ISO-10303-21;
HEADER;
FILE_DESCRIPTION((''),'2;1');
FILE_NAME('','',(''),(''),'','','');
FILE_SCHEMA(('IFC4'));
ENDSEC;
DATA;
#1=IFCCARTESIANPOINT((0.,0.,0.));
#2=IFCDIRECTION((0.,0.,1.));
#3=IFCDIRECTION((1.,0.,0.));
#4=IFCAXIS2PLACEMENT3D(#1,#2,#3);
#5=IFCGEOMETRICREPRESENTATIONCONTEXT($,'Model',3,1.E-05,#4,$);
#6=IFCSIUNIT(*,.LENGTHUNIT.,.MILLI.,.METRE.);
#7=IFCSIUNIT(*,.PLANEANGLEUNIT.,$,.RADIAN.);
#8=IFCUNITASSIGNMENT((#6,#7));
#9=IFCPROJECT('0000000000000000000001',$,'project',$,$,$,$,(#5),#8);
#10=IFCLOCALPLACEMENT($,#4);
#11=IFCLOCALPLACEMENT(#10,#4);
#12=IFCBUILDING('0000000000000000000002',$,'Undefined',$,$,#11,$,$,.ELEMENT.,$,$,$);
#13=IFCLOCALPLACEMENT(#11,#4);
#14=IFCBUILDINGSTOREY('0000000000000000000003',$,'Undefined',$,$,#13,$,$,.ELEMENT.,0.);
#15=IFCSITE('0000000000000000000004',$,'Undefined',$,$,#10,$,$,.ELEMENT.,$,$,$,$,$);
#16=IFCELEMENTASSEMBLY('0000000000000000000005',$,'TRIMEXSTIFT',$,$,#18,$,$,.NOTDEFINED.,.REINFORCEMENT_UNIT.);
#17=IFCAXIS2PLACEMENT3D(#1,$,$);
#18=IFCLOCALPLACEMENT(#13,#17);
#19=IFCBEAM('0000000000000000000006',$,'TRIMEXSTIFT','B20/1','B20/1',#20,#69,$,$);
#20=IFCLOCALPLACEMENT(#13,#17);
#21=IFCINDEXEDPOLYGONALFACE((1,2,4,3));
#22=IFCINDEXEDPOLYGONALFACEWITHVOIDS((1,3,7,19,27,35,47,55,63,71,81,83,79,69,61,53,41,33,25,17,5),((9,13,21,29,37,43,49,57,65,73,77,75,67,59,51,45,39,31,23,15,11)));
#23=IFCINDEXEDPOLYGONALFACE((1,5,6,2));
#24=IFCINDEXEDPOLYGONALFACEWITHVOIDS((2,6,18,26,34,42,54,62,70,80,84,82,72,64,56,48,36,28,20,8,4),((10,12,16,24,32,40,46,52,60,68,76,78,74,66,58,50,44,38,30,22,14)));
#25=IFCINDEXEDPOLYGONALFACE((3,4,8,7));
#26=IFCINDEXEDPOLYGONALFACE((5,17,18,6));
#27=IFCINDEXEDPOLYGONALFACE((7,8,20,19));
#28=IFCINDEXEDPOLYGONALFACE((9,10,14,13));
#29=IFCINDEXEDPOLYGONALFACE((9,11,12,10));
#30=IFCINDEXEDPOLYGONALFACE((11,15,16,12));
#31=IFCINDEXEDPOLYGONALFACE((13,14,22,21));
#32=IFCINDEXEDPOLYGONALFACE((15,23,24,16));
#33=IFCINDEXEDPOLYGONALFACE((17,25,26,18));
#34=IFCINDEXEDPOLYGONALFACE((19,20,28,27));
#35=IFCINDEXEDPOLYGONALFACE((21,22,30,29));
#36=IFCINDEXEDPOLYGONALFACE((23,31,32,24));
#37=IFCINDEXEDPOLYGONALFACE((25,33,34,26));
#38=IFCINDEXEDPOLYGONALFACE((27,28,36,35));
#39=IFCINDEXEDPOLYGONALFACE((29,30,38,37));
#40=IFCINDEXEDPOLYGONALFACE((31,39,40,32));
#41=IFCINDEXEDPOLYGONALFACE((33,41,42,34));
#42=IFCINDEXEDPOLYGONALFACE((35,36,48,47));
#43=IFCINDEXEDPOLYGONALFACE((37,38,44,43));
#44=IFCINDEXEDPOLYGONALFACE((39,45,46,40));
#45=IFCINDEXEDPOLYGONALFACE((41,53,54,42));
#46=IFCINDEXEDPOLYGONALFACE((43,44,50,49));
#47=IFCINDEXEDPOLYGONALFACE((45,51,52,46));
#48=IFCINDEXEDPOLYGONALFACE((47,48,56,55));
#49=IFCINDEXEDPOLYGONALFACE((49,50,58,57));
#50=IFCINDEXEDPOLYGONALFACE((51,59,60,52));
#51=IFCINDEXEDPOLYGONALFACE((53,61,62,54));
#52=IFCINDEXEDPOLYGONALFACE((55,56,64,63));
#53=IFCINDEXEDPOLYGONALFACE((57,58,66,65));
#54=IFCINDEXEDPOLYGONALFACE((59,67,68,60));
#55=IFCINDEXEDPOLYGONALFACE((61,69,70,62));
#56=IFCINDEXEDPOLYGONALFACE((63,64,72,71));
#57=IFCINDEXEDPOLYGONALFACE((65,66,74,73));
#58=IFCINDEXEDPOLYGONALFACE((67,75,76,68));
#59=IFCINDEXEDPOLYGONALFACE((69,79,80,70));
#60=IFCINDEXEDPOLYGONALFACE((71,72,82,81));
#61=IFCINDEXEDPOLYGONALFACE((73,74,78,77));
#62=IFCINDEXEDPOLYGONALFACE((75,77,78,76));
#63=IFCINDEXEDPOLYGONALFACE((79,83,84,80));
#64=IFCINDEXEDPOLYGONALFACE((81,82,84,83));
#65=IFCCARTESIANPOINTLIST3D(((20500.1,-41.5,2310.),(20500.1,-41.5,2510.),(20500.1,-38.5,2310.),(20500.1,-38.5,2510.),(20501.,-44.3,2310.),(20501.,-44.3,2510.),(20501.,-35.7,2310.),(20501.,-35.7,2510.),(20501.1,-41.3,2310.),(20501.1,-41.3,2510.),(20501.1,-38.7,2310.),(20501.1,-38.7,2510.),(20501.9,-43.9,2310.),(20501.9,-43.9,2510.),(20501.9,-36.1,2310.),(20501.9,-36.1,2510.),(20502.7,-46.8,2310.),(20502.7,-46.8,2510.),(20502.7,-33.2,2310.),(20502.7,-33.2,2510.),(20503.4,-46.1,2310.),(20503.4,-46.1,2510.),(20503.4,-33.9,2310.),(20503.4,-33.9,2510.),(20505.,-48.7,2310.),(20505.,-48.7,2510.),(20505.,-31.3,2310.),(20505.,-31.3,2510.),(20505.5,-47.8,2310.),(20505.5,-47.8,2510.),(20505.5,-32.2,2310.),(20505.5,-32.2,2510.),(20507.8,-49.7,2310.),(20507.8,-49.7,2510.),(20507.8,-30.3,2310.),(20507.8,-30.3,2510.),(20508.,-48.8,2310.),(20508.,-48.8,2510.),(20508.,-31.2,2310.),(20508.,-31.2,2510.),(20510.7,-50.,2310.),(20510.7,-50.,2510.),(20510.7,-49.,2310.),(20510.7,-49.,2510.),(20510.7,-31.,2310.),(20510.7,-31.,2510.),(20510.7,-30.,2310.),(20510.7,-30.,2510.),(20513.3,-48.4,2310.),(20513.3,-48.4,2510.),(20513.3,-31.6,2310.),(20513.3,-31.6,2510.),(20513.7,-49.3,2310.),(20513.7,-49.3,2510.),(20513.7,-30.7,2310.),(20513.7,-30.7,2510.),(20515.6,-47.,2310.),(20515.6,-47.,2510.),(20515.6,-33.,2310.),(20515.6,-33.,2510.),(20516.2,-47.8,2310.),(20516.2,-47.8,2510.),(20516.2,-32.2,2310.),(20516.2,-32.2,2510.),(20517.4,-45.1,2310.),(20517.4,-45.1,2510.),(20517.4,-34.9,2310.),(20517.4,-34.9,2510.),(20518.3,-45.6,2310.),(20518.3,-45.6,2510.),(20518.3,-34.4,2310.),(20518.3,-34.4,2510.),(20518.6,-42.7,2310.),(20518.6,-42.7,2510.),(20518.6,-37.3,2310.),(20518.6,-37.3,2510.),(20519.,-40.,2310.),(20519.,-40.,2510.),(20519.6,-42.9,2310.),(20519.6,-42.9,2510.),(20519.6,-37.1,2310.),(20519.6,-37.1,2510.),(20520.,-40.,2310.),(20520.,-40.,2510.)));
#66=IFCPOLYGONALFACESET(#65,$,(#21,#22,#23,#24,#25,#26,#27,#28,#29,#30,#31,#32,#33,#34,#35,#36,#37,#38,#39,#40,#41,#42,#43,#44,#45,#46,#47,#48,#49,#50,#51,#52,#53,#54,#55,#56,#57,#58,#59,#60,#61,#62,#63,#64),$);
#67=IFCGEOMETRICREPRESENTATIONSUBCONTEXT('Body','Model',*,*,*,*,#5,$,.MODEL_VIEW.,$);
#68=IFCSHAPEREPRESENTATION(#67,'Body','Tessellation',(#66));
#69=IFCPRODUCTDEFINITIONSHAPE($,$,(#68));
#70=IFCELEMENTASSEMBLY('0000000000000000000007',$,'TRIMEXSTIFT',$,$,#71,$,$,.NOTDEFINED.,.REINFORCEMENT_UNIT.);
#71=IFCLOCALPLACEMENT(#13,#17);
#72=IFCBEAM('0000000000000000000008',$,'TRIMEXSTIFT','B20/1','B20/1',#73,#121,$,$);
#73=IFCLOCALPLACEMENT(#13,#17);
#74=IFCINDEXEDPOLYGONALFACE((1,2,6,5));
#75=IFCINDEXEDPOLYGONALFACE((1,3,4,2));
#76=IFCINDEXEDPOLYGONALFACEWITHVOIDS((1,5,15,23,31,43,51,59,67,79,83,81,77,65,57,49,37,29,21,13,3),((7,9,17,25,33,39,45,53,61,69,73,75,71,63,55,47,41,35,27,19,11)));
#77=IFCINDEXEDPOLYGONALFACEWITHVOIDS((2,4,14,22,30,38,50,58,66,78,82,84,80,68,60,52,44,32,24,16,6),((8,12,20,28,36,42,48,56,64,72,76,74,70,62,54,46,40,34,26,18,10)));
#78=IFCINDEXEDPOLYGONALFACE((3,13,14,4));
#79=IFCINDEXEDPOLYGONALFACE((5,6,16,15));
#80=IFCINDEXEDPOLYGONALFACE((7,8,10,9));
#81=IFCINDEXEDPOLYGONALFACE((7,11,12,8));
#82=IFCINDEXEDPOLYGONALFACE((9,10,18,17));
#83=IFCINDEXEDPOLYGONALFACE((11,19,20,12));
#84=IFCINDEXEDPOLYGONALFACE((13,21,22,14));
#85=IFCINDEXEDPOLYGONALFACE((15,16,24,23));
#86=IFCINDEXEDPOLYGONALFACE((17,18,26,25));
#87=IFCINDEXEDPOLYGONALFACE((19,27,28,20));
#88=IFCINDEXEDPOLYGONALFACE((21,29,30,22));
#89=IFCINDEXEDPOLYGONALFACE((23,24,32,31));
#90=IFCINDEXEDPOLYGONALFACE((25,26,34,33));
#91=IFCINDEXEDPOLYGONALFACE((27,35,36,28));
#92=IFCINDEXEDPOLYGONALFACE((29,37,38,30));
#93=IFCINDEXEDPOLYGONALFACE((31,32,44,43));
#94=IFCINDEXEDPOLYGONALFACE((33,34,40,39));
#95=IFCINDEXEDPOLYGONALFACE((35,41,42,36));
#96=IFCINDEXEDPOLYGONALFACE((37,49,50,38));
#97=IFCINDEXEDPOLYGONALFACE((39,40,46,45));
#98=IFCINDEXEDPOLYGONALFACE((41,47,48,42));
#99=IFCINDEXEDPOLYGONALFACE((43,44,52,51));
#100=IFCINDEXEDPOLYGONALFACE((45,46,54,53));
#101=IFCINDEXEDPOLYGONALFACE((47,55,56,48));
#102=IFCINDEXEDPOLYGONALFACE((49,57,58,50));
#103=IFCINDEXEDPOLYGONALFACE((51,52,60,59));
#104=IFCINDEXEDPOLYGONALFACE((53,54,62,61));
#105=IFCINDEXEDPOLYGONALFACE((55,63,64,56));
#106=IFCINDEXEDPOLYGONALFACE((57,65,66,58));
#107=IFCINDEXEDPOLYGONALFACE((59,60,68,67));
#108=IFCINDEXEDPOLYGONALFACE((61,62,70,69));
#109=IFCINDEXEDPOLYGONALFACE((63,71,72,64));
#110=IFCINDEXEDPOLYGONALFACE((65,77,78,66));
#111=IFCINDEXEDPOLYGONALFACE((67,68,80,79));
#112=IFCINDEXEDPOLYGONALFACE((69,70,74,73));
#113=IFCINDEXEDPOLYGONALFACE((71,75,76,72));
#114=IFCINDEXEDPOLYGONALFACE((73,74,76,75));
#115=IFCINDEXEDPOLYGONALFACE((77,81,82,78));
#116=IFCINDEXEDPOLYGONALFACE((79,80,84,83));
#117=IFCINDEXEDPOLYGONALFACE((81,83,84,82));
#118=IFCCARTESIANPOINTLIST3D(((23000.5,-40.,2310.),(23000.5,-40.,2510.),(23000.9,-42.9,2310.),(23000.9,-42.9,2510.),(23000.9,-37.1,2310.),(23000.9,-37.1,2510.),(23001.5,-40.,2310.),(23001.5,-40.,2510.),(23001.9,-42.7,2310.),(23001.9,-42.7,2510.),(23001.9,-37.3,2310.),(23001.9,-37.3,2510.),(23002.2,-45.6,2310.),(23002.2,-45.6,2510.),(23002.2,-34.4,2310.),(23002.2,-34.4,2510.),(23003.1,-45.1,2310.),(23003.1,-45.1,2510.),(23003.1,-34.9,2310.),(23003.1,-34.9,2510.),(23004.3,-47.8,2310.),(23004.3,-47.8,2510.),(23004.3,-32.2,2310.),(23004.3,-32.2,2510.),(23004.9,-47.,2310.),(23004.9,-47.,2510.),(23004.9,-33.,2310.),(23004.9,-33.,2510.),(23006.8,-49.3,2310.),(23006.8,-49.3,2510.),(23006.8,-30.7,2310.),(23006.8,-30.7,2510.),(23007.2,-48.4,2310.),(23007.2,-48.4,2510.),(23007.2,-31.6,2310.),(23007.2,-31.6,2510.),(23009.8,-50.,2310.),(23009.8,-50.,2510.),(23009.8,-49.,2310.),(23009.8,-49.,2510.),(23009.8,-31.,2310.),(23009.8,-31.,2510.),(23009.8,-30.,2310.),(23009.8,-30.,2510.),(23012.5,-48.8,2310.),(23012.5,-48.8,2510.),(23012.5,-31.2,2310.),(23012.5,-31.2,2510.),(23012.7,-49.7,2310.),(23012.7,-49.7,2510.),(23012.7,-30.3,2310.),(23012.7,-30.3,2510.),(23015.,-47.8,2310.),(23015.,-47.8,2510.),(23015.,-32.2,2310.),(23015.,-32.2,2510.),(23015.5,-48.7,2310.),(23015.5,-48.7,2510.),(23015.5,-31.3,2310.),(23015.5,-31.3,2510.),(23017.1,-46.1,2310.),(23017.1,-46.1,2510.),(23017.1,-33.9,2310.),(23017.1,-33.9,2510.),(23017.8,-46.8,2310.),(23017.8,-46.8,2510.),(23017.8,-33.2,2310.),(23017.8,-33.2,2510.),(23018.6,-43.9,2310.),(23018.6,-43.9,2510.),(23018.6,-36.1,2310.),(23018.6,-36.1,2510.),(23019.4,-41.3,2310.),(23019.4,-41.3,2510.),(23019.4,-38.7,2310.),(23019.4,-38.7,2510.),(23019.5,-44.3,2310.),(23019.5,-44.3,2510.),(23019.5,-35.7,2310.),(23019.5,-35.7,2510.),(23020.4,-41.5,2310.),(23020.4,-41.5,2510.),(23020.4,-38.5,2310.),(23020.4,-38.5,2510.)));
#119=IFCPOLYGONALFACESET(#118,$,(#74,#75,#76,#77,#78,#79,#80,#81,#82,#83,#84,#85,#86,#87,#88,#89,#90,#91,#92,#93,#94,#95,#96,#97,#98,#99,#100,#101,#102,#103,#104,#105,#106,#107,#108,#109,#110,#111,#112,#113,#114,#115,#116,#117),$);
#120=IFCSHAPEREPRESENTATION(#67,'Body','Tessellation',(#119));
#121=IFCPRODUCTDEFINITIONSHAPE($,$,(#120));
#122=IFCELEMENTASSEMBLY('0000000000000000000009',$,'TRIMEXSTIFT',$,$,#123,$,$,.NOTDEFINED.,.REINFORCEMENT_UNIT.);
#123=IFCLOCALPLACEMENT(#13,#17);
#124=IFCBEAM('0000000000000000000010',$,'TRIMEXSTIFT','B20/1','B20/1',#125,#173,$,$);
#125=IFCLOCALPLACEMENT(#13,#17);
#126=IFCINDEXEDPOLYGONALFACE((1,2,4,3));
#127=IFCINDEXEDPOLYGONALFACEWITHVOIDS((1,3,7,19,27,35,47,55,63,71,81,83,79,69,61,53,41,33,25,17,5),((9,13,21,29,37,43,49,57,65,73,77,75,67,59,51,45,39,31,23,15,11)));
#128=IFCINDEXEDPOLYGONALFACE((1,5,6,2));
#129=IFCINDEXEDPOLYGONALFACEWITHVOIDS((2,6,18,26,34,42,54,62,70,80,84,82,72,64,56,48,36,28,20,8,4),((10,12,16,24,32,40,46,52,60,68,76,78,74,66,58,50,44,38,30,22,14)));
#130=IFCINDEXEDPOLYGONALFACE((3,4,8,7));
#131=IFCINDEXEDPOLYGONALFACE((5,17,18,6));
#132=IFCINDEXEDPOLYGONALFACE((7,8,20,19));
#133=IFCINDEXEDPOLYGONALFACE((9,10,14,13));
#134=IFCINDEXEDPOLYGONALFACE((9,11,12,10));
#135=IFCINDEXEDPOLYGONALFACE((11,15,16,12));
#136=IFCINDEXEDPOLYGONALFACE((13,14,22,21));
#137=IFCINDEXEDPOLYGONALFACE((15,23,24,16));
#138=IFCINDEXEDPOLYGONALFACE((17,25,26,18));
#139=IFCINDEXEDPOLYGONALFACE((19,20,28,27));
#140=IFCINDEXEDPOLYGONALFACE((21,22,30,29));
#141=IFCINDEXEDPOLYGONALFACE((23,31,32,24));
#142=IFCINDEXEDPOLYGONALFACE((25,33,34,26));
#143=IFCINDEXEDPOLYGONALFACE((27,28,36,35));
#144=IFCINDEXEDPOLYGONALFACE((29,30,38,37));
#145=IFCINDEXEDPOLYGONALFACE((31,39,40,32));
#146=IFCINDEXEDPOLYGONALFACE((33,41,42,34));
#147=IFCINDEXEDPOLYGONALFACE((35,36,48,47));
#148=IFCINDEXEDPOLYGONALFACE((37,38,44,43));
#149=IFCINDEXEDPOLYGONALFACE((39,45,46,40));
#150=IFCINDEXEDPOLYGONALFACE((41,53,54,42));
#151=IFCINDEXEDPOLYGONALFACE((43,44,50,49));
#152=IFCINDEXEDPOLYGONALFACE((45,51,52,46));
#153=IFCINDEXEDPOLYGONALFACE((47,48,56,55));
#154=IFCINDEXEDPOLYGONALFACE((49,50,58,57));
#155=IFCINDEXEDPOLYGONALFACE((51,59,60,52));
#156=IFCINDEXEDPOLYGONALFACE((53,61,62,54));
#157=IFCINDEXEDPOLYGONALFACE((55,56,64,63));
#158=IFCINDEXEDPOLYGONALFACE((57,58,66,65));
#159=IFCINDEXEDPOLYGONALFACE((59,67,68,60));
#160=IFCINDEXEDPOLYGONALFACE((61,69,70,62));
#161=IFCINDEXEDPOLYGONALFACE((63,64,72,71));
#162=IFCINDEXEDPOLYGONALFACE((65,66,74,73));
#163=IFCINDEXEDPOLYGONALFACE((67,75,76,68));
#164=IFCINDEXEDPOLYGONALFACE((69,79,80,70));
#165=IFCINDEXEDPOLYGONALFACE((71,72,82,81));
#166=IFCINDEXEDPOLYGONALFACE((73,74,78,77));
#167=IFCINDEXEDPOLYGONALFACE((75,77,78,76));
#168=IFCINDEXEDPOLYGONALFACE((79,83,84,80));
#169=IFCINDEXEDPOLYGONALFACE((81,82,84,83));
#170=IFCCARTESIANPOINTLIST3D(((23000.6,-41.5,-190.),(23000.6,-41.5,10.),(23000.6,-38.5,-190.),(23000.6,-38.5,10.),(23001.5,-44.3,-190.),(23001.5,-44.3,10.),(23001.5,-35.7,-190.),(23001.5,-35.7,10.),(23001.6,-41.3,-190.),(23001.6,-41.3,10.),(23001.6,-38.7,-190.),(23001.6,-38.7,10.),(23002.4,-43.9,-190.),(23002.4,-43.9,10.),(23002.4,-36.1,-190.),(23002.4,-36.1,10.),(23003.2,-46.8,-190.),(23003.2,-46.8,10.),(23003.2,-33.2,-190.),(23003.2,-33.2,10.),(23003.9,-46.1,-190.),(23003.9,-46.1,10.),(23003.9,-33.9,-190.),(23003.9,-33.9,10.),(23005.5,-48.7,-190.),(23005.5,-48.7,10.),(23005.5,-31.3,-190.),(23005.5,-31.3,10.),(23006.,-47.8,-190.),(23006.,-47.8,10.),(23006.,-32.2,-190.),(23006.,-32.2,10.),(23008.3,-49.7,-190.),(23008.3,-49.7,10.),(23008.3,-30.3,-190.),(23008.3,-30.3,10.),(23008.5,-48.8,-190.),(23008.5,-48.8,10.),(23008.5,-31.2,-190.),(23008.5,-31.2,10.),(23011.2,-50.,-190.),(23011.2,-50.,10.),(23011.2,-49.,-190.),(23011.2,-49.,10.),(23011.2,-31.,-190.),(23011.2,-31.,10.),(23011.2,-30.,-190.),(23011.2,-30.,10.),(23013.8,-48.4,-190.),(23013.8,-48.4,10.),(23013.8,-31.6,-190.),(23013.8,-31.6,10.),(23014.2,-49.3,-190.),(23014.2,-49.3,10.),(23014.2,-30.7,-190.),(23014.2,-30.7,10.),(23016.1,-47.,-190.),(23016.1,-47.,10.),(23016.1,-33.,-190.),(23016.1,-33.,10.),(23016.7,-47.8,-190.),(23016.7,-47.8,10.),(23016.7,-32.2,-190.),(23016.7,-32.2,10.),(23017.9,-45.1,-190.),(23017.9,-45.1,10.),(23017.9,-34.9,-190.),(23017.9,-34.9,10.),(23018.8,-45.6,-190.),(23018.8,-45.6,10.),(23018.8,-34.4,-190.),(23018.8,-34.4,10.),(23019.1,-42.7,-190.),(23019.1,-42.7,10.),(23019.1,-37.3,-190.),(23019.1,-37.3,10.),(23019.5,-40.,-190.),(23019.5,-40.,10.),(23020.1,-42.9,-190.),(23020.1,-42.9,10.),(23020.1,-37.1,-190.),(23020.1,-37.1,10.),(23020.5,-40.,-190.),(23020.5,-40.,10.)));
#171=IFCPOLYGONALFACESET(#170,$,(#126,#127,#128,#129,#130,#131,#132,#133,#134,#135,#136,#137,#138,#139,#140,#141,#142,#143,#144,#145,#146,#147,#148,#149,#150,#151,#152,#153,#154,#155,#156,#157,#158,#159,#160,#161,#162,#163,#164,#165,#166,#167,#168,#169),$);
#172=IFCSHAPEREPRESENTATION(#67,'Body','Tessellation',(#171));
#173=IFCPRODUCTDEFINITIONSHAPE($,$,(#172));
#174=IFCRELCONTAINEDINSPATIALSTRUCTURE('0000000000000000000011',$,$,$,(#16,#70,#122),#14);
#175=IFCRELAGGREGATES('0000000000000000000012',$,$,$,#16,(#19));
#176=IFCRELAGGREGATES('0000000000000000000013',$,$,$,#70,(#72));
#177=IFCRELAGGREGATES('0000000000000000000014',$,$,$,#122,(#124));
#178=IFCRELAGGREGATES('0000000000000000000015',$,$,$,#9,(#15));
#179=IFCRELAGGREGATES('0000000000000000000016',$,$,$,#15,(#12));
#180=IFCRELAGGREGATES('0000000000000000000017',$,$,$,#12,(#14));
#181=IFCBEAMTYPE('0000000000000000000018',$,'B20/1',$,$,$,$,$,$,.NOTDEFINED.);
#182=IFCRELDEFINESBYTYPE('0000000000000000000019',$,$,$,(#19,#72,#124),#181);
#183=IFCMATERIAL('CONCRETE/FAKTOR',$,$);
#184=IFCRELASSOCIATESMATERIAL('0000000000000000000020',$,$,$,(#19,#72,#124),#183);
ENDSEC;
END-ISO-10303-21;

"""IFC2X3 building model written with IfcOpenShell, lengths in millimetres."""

from ifc_helpers import new_model, si_unit, frame, frame_2d, origin_with_axes, place, context, subcontext, project, spatial, hollow_circle, extrude, material, type_object, element, aggregate, save


model = new_model("IFC2X3")

# Units and contexts
model_context = context("Model", 3, precision=1e-05, world=origin_with_axes())
body_context = subcontext(model_context, "Body", "Model", "MODEL_VIEW")
ifc_project = project(units=[si_unit("LENGTHUNIT", "METRE", prefix="MILLI"), si_unit("PLANEANGLEUNIT", "RADIAN")], contexts=[model_context])

# Site, building, storey
site_placement = place(None, origin_with_axes())
site = spatial("IfcSite", under=ifc_project, at=site_placement, Name="Undefined", CompositionType="ELEMENT")
building_placement = place(site_placement, origin_with_axes())
building = spatial("IfcBuilding", under=site, at=building_placement, Name="Undefined", CompositionType="ELEMENT")
storey_placement = place(building_placement, origin_with_axes())
storey = spatial("IfcBuildingStorey", under=building, at=storey_placement, Name="Undefined", CompositionType="ELEMENT", Elevation=0.0)

# Element assemblies, beams
assembly_1_placement = place(storey_placement, origin_with_axes())
assembly_1 = element("IfcElementAssembly", 1, at=assembly_1_placement, inside=storey, Name="TRIMEXSTIFT", AssemblyPlace="NOTDEFINED", PredefinedType="REINFORCEMENT_UNIT")
ifc_material_1 = material(Name="CONCRETE/FAKTOR")
beam_type_1 = type_object("IfcBeamType", Name="B20/1", PredefinedType="NOTDEFINED")
beam_1_placement = place(assembly_1_placement, frame((20510.0, -40.0, 2310.0), z_axis=(0.0, -1.0, 0.0), x_axis=(0.0, 0.0, 1.0)))
beam_1 = element("IfcBeam", 2, at=beam_1_placement, type_object=beam_type_1, material=ifc_material_1, Name="TRIMEXSTIFT", Description="B20/1", ObjectType="B20/1", context=body_context, shape_type="SweptSolid", body=[
    extrude(hollow_circle(Radius=10.0, WallThickness=1.0, at=frame_2d((0.0, 0.0), x_axis=(1.0, 0.0))), frame((200.0, 0.0, 0.0), z_axis=(-1.0, 0.0, 0.0), x_axis=(0.0, -1.0, 0.0)), (0.0, 0.0, 1.0), 200.0),
])
aggregate(assembly_1, [beam_1])
assembly_2_placement = place(storey_placement, origin_with_axes())
assembly_2 = element("IfcElementAssembly", 3, at=assembly_2_placement, inside=storey, Name="TRIMEXSTIFT", AssemblyPlace="NOTDEFINED", PredefinedType="REINFORCEMENT_UNIT")
beam_2_placement = place(assembly_2_placement, frame((23010.5, -40.0, 2310.0), z_axis=(0.0, 1.0, 0.0), x_axis=(0.0, 0.0, 1.0)))
beam_2 = element("IfcBeam", 4, at=beam_2_placement, type_object=beam_type_1, material=ifc_material_1, Name="TRIMEXSTIFT", Description="B20/1", ObjectType="B20/1", context=body_context, shape_type="SweptSolid", body=[
    extrude(hollow_circle(Radius=10.0, WallThickness=1.0, at=frame_2d((0.0, 0.0), x_axis=(1.0, 0.0))), frame((200.0, 0.0, 0.0), z_axis=(-1.0, 0.0, 0.0), x_axis=(0.0, -1.0, 0.0)), (0.0, 0.0, 1.0), 200.0),
])
aggregate(assembly_2, [beam_2])
assembly_3_placement = place(storey_placement, origin_with_axes())
assembly_3 = element("IfcElementAssembly", 5, at=assembly_3_placement, inside=storey, Name="TRIMEXSTIFT", AssemblyPlace="NOTDEFINED", PredefinedType="REINFORCEMENT_UNIT")
beam_3_placement = place(assembly_3_placement, frame((23010.5, -40.0, -190.0), z_axis=(0.0, -1.0, 0.0), x_axis=(0.0, 0.0, 1.0)))
beam_3 = element("IfcBeam", 6, at=beam_3_placement, type_object=beam_type_1, material=ifc_material_1, Name="TRIMEXSTIFT", Description="B20/1", ObjectType="B20/1", context=body_context, shape_type="SweptSolid", body=[
    extrude(hollow_circle(Radius=10.0, WallThickness=1.0, at=frame_2d((0.0, 0.0), x_axis=(1.0, 0.0))), frame((200.0, 0.0, 0.0), z_axis=(-1.0, 0.0, 0.0), x_axis=(0.0, -1.0, 0.0)), (0.0, 0.0, 1.0), 200.0),
])
aggregate(assembly_3, [beam_3])

save(model, "model.ifc")
